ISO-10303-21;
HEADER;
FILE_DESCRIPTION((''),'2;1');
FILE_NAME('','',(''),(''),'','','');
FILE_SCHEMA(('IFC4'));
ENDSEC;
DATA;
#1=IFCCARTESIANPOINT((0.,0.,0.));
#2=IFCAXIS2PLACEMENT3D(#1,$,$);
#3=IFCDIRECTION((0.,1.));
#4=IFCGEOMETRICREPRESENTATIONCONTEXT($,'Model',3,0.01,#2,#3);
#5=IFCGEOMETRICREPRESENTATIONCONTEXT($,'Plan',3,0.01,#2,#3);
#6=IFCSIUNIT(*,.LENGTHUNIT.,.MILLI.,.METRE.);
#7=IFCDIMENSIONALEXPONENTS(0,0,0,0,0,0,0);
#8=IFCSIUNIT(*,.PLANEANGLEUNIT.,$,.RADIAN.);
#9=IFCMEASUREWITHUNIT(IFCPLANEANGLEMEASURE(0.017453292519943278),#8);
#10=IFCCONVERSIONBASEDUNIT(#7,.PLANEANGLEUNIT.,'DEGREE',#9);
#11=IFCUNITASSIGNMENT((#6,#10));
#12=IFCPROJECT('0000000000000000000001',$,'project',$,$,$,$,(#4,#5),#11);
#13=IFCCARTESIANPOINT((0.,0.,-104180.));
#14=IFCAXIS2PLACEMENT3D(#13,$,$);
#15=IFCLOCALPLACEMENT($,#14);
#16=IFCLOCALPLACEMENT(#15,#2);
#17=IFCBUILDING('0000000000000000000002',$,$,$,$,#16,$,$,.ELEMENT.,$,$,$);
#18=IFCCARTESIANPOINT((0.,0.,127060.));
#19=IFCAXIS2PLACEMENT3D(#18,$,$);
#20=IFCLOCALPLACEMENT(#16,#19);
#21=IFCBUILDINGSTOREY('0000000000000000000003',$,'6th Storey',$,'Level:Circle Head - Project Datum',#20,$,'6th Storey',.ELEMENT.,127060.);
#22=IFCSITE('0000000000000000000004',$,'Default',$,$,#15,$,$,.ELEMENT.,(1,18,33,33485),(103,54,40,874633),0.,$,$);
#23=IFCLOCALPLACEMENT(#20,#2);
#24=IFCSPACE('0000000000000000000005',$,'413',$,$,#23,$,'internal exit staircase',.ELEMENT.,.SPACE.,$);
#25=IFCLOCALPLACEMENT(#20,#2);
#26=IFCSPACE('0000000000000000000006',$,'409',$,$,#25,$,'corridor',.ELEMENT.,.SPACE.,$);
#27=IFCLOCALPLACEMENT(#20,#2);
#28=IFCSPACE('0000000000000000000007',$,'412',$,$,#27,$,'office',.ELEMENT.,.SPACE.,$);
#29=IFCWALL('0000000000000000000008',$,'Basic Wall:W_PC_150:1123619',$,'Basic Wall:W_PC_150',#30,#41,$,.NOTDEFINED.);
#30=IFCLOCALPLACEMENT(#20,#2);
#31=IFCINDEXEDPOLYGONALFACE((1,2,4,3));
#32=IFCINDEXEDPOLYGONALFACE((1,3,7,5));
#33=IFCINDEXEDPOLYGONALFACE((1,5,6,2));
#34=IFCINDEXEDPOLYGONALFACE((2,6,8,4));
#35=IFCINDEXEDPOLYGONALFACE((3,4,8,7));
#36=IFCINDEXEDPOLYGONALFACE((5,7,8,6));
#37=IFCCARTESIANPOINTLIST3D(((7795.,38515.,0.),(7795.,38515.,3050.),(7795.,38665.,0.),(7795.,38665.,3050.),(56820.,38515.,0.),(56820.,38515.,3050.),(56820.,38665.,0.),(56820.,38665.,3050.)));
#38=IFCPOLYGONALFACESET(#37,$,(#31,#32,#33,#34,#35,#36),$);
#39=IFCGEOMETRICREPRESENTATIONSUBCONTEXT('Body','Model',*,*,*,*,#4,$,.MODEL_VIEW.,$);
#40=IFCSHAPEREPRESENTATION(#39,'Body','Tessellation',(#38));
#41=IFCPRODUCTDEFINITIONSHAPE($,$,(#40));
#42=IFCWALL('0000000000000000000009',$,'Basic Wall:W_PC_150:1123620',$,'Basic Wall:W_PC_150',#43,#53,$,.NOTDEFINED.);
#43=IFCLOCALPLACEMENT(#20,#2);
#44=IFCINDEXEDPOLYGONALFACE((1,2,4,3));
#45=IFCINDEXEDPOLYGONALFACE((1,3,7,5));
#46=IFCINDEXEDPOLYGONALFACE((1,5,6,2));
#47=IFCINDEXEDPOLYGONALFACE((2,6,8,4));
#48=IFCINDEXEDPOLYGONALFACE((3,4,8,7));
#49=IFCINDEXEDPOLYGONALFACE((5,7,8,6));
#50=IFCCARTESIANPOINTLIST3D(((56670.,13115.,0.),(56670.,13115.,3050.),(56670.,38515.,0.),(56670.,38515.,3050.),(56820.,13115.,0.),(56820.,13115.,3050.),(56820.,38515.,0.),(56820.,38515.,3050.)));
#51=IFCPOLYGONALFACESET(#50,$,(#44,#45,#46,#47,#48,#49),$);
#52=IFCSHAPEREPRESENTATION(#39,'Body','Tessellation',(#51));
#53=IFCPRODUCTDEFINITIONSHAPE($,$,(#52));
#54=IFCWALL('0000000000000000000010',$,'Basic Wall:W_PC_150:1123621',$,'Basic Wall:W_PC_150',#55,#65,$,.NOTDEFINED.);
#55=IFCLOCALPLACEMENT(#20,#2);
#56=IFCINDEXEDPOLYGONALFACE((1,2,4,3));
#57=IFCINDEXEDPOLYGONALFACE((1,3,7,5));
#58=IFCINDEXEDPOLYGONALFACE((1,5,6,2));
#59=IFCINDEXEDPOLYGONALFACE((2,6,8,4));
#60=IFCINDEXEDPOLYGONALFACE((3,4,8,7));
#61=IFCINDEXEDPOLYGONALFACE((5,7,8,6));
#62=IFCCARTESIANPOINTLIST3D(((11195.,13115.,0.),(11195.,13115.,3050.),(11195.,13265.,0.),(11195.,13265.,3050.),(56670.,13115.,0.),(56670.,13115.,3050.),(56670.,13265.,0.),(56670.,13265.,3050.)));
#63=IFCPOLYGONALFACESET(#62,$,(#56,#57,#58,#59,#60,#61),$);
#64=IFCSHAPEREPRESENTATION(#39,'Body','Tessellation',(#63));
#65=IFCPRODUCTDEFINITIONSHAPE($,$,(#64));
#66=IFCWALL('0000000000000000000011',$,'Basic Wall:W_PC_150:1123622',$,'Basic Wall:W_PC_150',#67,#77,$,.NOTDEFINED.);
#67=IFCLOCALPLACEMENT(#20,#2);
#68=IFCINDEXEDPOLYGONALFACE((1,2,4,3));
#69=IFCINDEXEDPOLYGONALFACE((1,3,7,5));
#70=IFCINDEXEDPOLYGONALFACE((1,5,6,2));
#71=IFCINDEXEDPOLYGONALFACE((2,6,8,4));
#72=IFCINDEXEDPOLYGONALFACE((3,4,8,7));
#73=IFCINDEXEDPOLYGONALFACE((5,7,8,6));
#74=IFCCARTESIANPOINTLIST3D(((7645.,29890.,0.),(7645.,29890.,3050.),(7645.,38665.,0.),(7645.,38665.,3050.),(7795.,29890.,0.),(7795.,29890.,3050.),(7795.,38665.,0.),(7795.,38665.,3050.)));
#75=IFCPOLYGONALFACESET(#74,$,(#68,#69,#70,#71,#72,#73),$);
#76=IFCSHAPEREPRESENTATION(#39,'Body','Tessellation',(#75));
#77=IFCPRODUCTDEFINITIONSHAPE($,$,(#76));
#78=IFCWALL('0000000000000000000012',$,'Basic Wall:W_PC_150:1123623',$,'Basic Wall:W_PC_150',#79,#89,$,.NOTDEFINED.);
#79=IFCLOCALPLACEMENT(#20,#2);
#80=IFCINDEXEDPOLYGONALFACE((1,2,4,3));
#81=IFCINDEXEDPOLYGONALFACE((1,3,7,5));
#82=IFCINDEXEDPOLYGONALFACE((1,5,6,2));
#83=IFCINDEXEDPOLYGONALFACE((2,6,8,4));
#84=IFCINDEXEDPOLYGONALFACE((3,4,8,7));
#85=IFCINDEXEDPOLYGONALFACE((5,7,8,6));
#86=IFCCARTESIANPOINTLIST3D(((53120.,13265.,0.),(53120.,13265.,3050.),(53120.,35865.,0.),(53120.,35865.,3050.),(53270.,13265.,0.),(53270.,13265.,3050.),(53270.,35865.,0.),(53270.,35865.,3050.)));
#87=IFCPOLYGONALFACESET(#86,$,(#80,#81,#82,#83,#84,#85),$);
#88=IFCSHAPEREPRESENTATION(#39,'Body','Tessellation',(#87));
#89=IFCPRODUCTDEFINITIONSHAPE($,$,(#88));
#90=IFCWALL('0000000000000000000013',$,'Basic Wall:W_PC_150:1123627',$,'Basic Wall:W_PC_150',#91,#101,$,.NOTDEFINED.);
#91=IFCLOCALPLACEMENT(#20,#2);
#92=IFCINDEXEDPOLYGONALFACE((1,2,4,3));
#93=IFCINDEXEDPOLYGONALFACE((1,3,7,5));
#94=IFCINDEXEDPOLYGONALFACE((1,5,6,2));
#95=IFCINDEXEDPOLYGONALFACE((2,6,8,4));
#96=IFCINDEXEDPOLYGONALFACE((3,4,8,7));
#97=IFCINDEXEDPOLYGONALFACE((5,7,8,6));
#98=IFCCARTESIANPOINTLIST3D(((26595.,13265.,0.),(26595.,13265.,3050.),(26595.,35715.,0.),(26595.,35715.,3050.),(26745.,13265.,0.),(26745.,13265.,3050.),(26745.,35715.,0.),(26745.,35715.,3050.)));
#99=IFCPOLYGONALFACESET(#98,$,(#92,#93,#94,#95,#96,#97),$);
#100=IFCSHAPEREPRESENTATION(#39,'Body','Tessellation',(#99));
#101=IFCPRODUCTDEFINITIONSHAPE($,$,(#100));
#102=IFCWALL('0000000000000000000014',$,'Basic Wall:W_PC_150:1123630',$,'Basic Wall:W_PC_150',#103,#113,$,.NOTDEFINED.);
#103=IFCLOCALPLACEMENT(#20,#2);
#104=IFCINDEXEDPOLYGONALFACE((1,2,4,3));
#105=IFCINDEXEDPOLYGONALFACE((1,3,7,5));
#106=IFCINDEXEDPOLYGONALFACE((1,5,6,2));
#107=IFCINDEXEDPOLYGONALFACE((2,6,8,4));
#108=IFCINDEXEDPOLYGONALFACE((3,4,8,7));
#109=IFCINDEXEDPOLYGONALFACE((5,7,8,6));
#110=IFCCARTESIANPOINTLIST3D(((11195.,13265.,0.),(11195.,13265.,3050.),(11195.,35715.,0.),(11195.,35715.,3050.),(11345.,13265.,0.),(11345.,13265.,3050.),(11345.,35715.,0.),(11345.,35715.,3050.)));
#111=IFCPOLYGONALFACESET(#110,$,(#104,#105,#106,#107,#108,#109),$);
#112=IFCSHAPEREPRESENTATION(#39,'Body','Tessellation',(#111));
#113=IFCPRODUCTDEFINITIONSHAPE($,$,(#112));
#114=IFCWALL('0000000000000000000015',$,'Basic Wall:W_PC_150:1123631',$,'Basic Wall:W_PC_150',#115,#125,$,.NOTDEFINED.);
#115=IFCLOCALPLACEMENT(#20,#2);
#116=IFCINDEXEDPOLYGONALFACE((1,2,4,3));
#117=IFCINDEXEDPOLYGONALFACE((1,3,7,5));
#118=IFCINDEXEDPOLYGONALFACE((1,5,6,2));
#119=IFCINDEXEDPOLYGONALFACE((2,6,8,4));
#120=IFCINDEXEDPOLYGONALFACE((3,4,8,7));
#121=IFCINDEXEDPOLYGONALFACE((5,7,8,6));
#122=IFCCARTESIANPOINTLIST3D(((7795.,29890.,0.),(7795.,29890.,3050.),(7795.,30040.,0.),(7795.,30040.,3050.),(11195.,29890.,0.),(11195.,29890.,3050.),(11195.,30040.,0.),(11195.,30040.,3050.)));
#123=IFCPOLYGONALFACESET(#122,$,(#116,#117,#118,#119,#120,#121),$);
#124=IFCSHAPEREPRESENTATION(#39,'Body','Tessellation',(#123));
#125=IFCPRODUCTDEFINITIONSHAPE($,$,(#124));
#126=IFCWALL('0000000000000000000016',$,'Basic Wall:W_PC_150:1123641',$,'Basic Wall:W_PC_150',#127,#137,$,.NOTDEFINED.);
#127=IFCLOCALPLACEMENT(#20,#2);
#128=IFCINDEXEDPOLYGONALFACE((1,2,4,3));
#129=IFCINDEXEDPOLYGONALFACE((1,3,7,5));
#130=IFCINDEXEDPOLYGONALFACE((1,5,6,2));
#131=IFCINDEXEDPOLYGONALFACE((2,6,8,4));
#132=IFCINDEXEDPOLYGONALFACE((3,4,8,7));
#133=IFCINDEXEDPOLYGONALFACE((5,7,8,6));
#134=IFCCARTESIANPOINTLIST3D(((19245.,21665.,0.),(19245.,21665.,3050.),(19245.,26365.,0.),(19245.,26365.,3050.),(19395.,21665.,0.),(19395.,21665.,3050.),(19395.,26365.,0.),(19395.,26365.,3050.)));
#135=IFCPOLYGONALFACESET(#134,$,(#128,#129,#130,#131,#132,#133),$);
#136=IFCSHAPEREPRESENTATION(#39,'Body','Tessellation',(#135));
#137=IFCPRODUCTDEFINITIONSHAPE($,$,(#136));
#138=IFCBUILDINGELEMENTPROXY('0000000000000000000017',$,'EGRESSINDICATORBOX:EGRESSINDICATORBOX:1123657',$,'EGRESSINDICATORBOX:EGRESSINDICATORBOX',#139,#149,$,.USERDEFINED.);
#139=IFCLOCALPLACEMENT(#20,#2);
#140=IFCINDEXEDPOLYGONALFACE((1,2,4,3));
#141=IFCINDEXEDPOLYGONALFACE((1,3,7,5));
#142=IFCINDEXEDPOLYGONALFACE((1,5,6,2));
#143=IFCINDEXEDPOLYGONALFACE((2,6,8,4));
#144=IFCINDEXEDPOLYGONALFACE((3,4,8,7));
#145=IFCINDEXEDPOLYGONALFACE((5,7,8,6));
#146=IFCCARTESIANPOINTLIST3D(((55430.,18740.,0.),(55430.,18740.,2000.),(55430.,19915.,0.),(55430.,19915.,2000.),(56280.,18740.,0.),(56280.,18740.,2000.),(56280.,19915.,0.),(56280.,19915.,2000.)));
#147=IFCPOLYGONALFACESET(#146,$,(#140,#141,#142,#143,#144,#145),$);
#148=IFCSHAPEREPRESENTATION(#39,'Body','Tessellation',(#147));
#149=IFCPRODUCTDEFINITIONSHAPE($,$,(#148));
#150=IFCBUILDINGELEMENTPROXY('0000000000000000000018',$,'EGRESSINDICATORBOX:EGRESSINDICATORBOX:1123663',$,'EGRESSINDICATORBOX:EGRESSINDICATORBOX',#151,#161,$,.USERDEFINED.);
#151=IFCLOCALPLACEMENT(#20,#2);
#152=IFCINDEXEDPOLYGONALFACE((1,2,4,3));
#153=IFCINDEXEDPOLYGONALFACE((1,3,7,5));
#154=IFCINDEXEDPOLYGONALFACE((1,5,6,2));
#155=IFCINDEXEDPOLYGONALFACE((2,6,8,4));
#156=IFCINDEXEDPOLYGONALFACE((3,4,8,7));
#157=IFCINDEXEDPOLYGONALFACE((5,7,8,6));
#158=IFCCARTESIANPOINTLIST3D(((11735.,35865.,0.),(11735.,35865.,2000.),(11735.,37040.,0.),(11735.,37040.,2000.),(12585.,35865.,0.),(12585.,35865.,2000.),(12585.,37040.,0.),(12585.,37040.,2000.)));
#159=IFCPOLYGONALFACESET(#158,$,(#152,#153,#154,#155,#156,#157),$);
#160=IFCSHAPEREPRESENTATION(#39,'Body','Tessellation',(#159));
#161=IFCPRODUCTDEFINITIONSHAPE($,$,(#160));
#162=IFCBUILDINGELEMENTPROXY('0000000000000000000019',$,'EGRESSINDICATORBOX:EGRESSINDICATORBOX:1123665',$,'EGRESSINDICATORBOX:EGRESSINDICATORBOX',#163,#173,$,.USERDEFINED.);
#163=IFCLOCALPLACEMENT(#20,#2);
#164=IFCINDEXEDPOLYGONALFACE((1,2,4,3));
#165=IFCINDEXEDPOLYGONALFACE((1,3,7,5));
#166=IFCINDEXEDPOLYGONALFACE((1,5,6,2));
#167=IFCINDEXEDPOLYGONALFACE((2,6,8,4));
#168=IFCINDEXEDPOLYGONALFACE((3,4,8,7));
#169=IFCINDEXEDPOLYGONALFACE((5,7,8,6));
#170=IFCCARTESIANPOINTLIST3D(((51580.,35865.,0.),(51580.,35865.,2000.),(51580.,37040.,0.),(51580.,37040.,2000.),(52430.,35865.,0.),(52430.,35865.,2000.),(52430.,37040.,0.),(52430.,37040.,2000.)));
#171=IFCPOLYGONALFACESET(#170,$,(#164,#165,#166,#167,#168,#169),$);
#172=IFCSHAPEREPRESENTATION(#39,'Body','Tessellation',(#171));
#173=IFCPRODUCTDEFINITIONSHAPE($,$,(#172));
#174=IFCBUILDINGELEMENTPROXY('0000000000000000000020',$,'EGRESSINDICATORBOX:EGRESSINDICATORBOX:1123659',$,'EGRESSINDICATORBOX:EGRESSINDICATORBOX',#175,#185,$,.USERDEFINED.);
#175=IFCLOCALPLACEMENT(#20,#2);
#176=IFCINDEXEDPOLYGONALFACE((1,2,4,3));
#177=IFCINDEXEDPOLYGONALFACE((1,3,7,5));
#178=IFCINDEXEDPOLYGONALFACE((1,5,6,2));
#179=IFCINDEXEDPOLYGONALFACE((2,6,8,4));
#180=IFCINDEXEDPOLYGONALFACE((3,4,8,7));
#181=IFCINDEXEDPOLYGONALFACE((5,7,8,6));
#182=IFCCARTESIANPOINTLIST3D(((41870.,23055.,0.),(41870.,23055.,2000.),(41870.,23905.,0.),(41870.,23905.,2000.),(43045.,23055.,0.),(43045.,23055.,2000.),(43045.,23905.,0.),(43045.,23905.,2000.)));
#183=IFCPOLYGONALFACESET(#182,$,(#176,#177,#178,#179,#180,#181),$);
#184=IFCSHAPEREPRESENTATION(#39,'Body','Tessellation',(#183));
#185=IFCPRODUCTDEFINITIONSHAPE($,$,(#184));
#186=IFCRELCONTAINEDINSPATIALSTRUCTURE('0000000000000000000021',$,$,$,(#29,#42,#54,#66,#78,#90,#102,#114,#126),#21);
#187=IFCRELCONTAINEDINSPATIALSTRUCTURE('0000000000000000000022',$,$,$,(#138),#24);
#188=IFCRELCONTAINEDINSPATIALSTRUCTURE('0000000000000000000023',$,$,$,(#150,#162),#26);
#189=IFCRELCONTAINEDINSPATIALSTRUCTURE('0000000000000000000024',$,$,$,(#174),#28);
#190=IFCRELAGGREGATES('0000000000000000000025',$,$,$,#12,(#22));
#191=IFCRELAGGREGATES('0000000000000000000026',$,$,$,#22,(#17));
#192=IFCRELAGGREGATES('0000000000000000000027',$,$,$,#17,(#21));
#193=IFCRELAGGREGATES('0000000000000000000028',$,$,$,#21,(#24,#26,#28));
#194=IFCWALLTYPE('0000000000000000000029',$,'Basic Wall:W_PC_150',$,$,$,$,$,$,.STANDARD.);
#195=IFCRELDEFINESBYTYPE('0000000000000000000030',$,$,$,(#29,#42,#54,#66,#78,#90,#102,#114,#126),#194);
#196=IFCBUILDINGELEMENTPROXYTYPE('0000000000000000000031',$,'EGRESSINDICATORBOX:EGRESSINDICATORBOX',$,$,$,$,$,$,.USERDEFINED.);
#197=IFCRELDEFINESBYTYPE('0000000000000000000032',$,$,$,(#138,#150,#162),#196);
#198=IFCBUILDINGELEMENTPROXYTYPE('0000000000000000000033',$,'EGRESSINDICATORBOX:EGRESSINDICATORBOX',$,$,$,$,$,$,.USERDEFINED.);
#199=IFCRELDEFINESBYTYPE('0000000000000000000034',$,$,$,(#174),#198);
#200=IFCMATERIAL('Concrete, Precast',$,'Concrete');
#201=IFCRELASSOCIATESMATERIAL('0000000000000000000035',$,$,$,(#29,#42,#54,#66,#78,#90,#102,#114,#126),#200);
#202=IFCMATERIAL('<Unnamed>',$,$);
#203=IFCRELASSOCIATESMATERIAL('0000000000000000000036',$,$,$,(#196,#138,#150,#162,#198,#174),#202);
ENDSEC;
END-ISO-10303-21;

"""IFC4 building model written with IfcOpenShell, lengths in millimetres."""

from ifc_helpers import new_model, entity, si_unit, converted_unit, direction, frame, origin, place, context, subcontext, project, spatial, indexed_curve, outline, extrude, source, transform, mapped, material, type_object, type_shapes, element, save


model = new_model("IFC4")

# Units and contexts
model_context = context("Model", 3, precision=0.01, world=origin(), true_north=direction((0.0, 1.0)))
plan_context = context("Plan", 3, precision=0.01, world=origin(), true_north=direction((0.0, 1.0)))
body_context = subcontext(model_context, "Body", "Model", "MODEL_VIEW")
ifc_project = project(units=[si_unit("LENGTHUNIT", "METRE", prefix="MILLI"), converted_unit("PLANEANGLEUNIT", "DEGREE", entity("IfcPlaneAngleMeasure", 0.017453292519943278), si_unit("PLANEANGLEUNIT", "RADIAN"), dimensions=[0, 0, 0, 0, 0, 0, 0])], contexts=[model_context, plan_context])

# Site, building, storey
site_placement = place(None, frame((0.0, 0.0, -104180.0)))
site = spatial("IfcSite", under=ifc_project, at=site_placement, Name="Default", CompositionType="ELEMENT", RefLatitude=(1, 18, 33, 33485), RefLongitude=(103, 54, 40, 874633), RefElevation=0.0)
building_placement = place(site_placement, origin())
building = spatial("IfcBuilding", under=site, at=building_placement, CompositionType="ELEMENT")
storey_placement = place(building_placement, frame((0.0, 0.0, 127060.0)))
storey = spatial("IfcBuildingStorey", under=building, at=storey_placement, Name="6th Storey", ObjectType="Level:Circle Head - Project Datum", LongName="6th Storey", CompositionType="ELEMENT", Elevation=127060.0)

# Shared definitions
ifc_material_1 = material(Name="Concrete, Precast", Category="Concrete")

# Walls
wall_type = type_object("IfcWallType", Name="Basic Wall:W_PC_150", PredefinedType="STANDARD")
wall_1_placement = place(storey_placement, frame((56820.0, 38590.0, 0.0), z_axis=(0.0, 0.0, 1.0), x_axis=(-1.0, 0.0, 0.0)))
element("IfcWall", 1, at=wall_1_placement, inside=storey, type_object=wall_type, material=ifc_material_1, Name="Basic Wall:W_PC_150:1123619", ObjectType="Basic Wall:W_PC_150", PredefinedType="NOTDEFINED", context=body_context, shape_type="SweptSolid", body=[
    extrude(outline(indexed_curve([(49025.0, 75.0), (0.0, 75.0), (0.0, -75.0), (49025.0, -75.0), (49025.0, 75.0)], self_intersect=False)), origin(), (0.0, 0.0, 1.0), 3050.0),
])
wall_2_placement = place(storey_placement, frame((56745.0, 13115.0, 0.0), z_axis=(0.0, 0.0, 1.0), x_axis=(0.0, 1.0, 0.0)))
element("IfcWall", 2, at=wall_2_placement, inside=storey, type_object=wall_type, material=ifc_material_1, Name="Basic Wall:W_PC_150:1123620", ObjectType="Basic Wall:W_PC_150", PredefinedType="NOTDEFINED", context=body_context, shape_type="SweptSolid", body=[
    extrude(outline(indexed_curve([(25400.0, 75.0), (0.0, 75.0), (0.0, -75.0), (25400.0, -75.0), (25400.0, 75.0)], self_intersect=False)), origin(), (0.0, 0.0, 1.0), 3050.0),
])
wall_3_placement = place(storey_placement, frame((11195.0, 13190.0, 0.0)))
element("IfcWall", 3, at=wall_3_placement, inside=storey, type_object=wall_type, material=ifc_material_1, Name="Basic Wall:W_PC_150:1123621", ObjectType="Basic Wall:W_PC_150", PredefinedType="NOTDEFINED", context=body_context, shape_type="SweptSolid", body=[
    extrude(outline(indexed_curve([(45475.0, 75.0), (0.0, 75.0), (0.0, -75.0), (45475.0, -75.0), (45475.0, 75.0)], self_intersect=False)), origin(), (0.0, 0.0, 1.0), 3050.0),
])
wall_4_placement = place(storey_placement, frame((7720.0, 38665.0, 0.0), z_axis=(0.0, 0.0, 1.0), x_axis=(0.0, -1.0, 0.0)))
element("IfcWall", 4, at=wall_4_placement, inside=storey, type_object=wall_type, material=ifc_material_1, Name="Basic Wall:W_PC_150:1123622", ObjectType="Basic Wall:W_PC_150", PredefinedType="NOTDEFINED", context=body_context, shape_type="SweptSolid", body=[
    extrude(outline(indexed_curve([(8775.0, 75.0), (0.0, 75.0), (0.0, -75.0), (8775.0, -75.0), (8775.0, 75.0)], self_intersect=False)), origin(), (0.0, 0.0, 1.0), 3050.0),
])
wall_5_placement = place(storey_placement, frame((53195.0, 13265.0, 0.0), z_axis=(0.0, 0.0, 1.0), x_axis=(0.0, 1.0, 0.0)))
element("IfcWall", 5, at=wall_5_placement, inside=storey, type_object=wall_type, material=ifc_material_1, Name="Basic Wall:W_PC_150:1123623", ObjectType="Basic Wall:W_PC_150", PredefinedType="NOTDEFINED", context=body_context, shape_type="SweptSolid", body=[
    extrude(outline(indexed_curve([(22600.0, 75.0), (0.0, 75.0), (0.0, -75.0), (22600.0, -75.0), (22600.0, 75.0)], self_intersect=False)), origin(), (0.0, 0.0, 1.0), 3050.0),
])
for number, where, z_axis, x_axis, name in (
    (6, (26670.0, 13265.0, 0.0), (0.0, 0.0, 1.0), (0.0, 1.0, 0.0), "Basic Wall:W_PC_150:1123627"),
    (7, (11270.0, 35715.0, 0.0), (0.0, 0.0, 1.0), (0.0, -1.0, 0.0), "Basic Wall:W_PC_150:1123630"),
):
    element("IfcWall", number, at=place(storey_placement, frame(where, z_axis=z_axis, x_axis=x_axis)), inside=storey, type_object=wall_type, material=ifc_material_1, Name=name, ObjectType="Basic Wall:W_PC_150", PredefinedType="NOTDEFINED", context=body_context, shape_type="SweptSolid", body=[
        extrude(outline(indexed_curve([(22450.0, 75.0), (0.0, 75.0), (0.0, -75.0), (22450.0, -75.0), (22450.0, 75.0)], self_intersect=False)), origin(), (0.0, 0.0, 1.0), 3050.0),
    ])
wall_6_placement = place(storey_placement, frame((7795.0, 29965.0, 0.0)))
element("IfcWall", 8, at=wall_6_placement, inside=storey, type_object=wall_type, material=ifc_material_1, Name="Basic Wall:W_PC_150:1123631", ObjectType="Basic Wall:W_PC_150", PredefinedType="NOTDEFINED", context=body_context, shape_type="SweptSolid", body=[
    extrude(outline(indexed_curve([(3400.0, 75.0), (0.0, 75.0), (0.0, -75.0), (3400.0, -75.0), (3400.0, 75.0)], self_intersect=False)), origin(), (0.0, 0.0, 1.0), 3050.0),
])
wall_7_placement = place(storey_placement, frame((19320.0, 21665.0, 0.0), z_axis=(0.0, 0.0, 1.0), x_axis=(0.0, 1.0, 0.0)))
element("IfcWall", 9, at=wall_7_placement, inside=storey, type_object=wall_type, material=ifc_material_1, Name="Basic Wall:W_PC_150:1123641", ObjectType="Basic Wall:W_PC_150", PredefinedType="NOTDEFINED", context=body_context, shape_type="SweptSolid", body=[
    extrude(outline(indexed_curve([(4700.0, 75.0), (0.0, 75.0), (0.0, -75.0), (4700.0, -75.0), (4700.0, 75.0)], self_intersect=False)), origin(), (0.0, 0.0, 1.0), 3050.0),
])

# Shared definitions
space_1_placement = place(storey_placement, origin())
space_1 = spatial("IfcSpace", under=storey, at=space_1_placement, Name="413", LongName="internal exit staircase", CompositionType="ELEMENT", PredefinedType="SPACE")

# Building element proxy
ifc_material_2 = material(Name="<Unnamed>")
building_element_proxy_type_1 = type_object("IfcBuildingElementProxyType", Name="EGRESSINDICATORBOX:EGRESSINDICATORBOX", PredefinedType="USERDEFINED", material=ifc_material_2)
shared_shape_1 = source(origin(), body_context, "Body", "SweptSolid", [
    extrude(outline(indexed_curve([(-587.5, -425.0), (587.5, -425.0), (587.5, 425.0), (-587.5, 425.0), (-587.5, -425.0)], self_intersect=False)), frame((0.0, 0.0, 0.0), z_axis=(0.0, 0.0, 1.0), x_axis=(0.0, 1.0, 0.0)), (0.0, 0.0, 1.0), 2000.0),
])
type_shapes(building_element_proxy_type_1, [shared_shape_1])
proxy_1_placement = place(space_1_placement, frame((55855.0, 19327.5, 0.0)))
element("IfcBuildingElementProxy", 10, at=proxy_1_placement, inside=space_1, type_object=building_element_proxy_type_1, material=ifc_material_2, Name="EGRESSINDICATORBOX:EGRESSINDICATORBOX:1123657", ObjectType="EGRESSINDICATORBOX:EGRESSINDICATORBOX", PredefinedType="USERDEFINED", context=body_context, shape_type="MappedRepresentation", body=[
    mapped(shared_shape_1, transform((0.0, 0.0, 0.0), scale=1.0)),
])

# Shared definitions
space_2_placement = place(storey_placement, origin())
space_2 = spatial("IfcSpace", under=storey, at=space_2_placement, Name="409", LongName="corridor", CompositionType="ELEMENT", PredefinedType="SPACE")

# Building element proxies
for number, where, z_axis, x_axis, name in (
    (11, (12160.0, 36452.5, 0.0), (0.0, 0.0, 1.0), (-1.0, 0.0, 0.0), "EGRESSINDICATORBOX:EGRESSINDICATORBOX:1123663"),
    (12, (52005.0, 36452.5, 0.0), (0.0, 0.0, 1.0), (-1.0, 0.0, 0.0), "EGRESSINDICATORBOX:EGRESSINDICATORBOX:1123665"),
):
    element("IfcBuildingElementProxy", number, at=place(space_2_placement, frame(where, z_axis=z_axis, x_axis=x_axis)), inside=space_2, type_object=building_element_proxy_type_1, material=ifc_material_2, Name=name, ObjectType="EGRESSINDICATORBOX:EGRESSINDICATORBOX", PredefinedType="USERDEFINED", context=body_context, shape_type="MappedRepresentation", body=[
        mapped(shared_shape_1, transform((0.0, 0.0, 0.0), scale=1.0)),
    ])

# Shared definitions
space_3_placement = place(storey_placement, origin())
space_3 = spatial("IfcSpace", under=storey, at=space_3_placement, Name="412", LongName="office", CompositionType="ELEMENT", PredefinedType="SPACE")

# Building element proxy
building_element_proxy_type_2 = type_object("IfcBuildingElementProxyType", Name="EGRESSINDICATORBOX:EGRESSINDICATORBOX", PredefinedType="USERDEFINED", material=ifc_material_2)
shared_shape_2 = source(origin(), body_context, "Body", "SweptSolid", [
    extrude(outline(indexed_curve([(-425.0, -587.5), (425.0, -587.5), (425.0, 587.5), (-425.0, 587.5), (-425.0, -587.5)], self_intersect=False)), frame((0.0, 0.0, 0.0), z_axis=(0.0, 0.0, 1.0), x_axis=(-1.0, 0.0, 0.0)), (0.0, 0.0, 1.0), 2000.0),
])
type_shapes(building_element_proxy_type_2, [shared_shape_2])
proxy_2_placement = place(space_3_placement, frame((42457.5, 23480.0, 0.0), z_axis=(0.0, 0.0, 1.0), x_axis=(0.0, -1.0, 0.0)))
element("IfcBuildingElementProxy", 13, at=proxy_2_placement, inside=space_3, type_object=building_element_proxy_type_2, material=ifc_material_2, Name="EGRESSINDICATORBOX:EGRESSINDICATORBOX:1123659", ObjectType="EGRESSINDICATORBOX:EGRESSINDICATORBOX", PredefinedType="USERDEFINED", context=body_context, shape_type="MappedRepresentation", body=[
    mapped(shared_shape_2, transform((0.0, 0.0, 0.0), scale=1.0)),
])

save(model, "model.ifc")
